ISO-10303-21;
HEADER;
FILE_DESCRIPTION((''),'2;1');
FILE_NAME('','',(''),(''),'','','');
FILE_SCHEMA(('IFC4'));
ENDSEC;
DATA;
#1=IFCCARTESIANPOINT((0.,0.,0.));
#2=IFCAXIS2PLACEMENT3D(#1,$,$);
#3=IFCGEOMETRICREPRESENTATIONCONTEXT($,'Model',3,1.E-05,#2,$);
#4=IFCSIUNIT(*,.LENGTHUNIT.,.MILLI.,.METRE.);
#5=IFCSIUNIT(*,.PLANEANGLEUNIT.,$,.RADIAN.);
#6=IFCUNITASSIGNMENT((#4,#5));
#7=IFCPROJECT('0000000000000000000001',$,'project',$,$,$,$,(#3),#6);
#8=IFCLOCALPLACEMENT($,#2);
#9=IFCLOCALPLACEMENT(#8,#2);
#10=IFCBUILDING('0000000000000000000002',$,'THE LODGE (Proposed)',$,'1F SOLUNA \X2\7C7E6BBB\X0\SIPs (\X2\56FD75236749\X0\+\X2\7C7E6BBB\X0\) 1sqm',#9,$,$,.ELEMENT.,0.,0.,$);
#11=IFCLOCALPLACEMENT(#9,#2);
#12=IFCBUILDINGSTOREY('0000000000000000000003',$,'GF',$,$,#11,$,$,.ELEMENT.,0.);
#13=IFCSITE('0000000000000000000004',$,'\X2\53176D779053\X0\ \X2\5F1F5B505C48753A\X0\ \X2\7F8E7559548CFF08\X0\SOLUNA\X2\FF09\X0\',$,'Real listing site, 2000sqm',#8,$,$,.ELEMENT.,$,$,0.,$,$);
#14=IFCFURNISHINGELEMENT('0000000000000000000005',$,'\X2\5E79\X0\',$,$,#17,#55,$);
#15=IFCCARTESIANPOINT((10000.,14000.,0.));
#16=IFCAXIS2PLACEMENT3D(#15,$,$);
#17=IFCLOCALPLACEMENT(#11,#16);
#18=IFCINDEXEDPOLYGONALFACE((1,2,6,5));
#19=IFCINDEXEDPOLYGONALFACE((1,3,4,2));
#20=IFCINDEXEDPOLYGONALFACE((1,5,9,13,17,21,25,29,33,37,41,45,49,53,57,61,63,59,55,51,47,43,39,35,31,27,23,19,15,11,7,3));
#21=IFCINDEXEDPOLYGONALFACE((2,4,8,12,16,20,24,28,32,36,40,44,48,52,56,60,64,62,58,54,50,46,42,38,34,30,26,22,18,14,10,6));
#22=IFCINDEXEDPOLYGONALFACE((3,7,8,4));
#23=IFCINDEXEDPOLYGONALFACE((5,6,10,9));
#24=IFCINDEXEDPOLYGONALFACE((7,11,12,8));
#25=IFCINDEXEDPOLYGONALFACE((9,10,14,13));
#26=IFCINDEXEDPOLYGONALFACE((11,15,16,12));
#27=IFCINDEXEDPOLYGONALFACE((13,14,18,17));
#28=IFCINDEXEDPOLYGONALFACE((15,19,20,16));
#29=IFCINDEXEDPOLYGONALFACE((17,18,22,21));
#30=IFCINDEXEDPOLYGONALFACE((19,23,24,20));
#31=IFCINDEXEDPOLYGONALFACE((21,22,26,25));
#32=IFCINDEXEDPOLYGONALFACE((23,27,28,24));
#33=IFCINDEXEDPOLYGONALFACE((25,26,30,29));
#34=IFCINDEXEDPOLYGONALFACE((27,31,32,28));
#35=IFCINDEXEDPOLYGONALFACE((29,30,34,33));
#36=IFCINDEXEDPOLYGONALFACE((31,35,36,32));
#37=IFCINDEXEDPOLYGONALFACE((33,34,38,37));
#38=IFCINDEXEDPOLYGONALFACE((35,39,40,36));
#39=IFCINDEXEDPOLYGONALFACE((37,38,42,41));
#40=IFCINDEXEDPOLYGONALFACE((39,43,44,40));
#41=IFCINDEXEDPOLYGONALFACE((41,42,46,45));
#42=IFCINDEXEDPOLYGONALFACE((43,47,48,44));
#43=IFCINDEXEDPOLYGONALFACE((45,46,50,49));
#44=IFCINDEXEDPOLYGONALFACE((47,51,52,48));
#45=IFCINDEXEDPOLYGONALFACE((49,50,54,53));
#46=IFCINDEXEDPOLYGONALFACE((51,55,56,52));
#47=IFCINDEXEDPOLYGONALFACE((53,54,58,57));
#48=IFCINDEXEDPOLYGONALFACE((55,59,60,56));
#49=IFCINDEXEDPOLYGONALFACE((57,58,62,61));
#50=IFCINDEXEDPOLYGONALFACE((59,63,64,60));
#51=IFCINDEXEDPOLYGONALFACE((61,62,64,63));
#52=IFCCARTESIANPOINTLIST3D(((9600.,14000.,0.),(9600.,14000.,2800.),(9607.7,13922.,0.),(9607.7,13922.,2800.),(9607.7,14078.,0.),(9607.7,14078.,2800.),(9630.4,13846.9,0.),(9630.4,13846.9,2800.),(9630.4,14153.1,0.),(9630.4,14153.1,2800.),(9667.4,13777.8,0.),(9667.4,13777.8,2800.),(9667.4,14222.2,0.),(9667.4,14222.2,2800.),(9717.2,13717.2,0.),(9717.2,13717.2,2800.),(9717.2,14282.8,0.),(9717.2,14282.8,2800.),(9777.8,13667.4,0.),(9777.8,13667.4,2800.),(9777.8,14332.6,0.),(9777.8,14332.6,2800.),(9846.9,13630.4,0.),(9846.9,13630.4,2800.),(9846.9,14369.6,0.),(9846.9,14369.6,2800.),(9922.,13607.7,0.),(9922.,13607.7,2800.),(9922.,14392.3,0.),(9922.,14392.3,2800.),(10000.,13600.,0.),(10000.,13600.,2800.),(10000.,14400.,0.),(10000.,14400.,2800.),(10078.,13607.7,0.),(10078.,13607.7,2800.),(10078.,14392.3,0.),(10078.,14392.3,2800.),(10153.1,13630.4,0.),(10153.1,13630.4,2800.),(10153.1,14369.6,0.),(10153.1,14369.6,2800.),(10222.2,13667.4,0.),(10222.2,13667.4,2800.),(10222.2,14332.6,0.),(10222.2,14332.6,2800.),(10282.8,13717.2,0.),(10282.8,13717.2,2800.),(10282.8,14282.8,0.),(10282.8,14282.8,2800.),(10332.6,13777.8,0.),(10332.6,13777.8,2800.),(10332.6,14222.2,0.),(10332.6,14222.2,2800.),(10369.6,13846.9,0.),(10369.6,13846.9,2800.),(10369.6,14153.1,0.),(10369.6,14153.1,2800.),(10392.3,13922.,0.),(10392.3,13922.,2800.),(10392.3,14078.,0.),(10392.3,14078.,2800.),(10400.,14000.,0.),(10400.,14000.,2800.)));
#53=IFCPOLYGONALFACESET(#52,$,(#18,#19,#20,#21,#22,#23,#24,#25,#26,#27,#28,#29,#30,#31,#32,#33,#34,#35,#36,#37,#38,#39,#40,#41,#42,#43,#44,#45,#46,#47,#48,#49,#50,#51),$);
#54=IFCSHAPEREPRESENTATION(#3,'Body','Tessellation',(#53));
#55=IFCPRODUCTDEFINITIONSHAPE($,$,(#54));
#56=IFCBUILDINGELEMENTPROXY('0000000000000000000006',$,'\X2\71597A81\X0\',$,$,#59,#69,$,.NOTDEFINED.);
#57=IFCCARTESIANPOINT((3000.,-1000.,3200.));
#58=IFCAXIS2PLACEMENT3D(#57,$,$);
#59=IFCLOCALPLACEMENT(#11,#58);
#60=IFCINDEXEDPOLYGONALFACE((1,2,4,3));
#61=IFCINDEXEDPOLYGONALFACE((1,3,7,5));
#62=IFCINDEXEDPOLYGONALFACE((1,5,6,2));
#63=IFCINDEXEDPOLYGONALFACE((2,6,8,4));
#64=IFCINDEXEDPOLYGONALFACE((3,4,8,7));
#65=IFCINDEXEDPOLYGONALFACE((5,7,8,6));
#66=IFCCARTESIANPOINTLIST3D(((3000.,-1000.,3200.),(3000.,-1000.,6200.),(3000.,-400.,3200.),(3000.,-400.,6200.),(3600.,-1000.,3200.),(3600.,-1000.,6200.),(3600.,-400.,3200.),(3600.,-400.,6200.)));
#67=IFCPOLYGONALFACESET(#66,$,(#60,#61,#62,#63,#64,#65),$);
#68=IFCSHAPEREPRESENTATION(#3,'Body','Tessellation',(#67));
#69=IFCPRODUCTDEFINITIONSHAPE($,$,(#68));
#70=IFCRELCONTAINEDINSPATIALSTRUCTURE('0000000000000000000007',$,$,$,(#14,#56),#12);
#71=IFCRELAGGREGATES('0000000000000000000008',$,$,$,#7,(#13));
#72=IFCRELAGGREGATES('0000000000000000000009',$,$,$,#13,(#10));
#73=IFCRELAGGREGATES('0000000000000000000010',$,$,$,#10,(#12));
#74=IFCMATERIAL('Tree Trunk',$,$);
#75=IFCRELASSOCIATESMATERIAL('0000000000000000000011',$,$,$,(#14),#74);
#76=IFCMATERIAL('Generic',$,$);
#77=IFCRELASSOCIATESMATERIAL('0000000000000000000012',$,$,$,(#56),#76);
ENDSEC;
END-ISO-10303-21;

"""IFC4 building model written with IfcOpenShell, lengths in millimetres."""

from ifc_helpers import new_model, si_unit, frame, frame_2d, origin, origin_2d, place, context, project, spatial, rectangle, circle, extrude, material, element, save


model = new_model("IFC4")

# Units and contexts
model_context = context("Model", 3, precision=1e-05, world=origin())
ifc_project = project(units=[si_unit("LENGTHUNIT", "METRE", prefix="MILLI"), si_unit("PLANEANGLEUNIT", "RADIAN")], contexts=[model_context])

# Site, building, storey
site_placement = place(None, origin())
site = spatial("IfcSite", under=ifc_project, at=site_placement, Name="北海道 弟子屈町 美留和（SOLUNA）", ObjectType="Real listing site, 2000sqm", CompositionType="ELEMENT", RefElevation=0.0)
building_placement = place(site_placement, origin())
building = spatial("IfcBuilding", under=site, at=building_placement, Name="THE LODGE (Proposed)", ObjectType="1F SOLUNA 籾殻SIPs (国産杉+籾殻) 1sqm", CompositionType="ELEMENT", ElevationOfRefHeight=0.0, ElevationOfTerrain=0.0)
storey_placement = place(building_placement, origin())
storey = spatial("IfcBuildingStorey", under=building, at=storey_placement, Name="GF", CompositionType="ELEMENT", Elevation=0.0)

# Shared definitions
ifc_material_1 = material(Name="Generic")

# Furnishing element
ifc_material_2 = material(Name="Tree Trunk")
furnishing_1_placement = place(storey_placement, frame((10000.0, 14000.0, 0.0)))
element("IfcFurnishingElement", 1, at=furnishing_1_placement, inside=storey, material=ifc_material_2, Name="幹", context=model_context, shape_type="SweptSolid", body=[
    extrude(circle(Radius=400.0, at=origin_2d()), frame((10000.0, 14000.0, 0.0)), (0.0, 0.0, 1.0), 2800.0),
])

# Building element proxy
proxy_placement = place(storey_placement, frame((3000.0, -1000.0, 3200.0)))
element("IfcBuildingElementProxy", 2, at=proxy_placement, inside=storey, material=ifc_material_1, Name="煙突", PredefinedType="NOTDEFINED", context=model_context, shape_type="SweptSolid", body=[
    extrude(rectangle(XDim=600.0, YDim=600.0, at=frame_2d((300.0, 300.0))), frame((3000.0, -1000.0, 3200.0)), (0.0, 0.0, 1.0), 3000.0),
])

save(model, "model.ifc")
